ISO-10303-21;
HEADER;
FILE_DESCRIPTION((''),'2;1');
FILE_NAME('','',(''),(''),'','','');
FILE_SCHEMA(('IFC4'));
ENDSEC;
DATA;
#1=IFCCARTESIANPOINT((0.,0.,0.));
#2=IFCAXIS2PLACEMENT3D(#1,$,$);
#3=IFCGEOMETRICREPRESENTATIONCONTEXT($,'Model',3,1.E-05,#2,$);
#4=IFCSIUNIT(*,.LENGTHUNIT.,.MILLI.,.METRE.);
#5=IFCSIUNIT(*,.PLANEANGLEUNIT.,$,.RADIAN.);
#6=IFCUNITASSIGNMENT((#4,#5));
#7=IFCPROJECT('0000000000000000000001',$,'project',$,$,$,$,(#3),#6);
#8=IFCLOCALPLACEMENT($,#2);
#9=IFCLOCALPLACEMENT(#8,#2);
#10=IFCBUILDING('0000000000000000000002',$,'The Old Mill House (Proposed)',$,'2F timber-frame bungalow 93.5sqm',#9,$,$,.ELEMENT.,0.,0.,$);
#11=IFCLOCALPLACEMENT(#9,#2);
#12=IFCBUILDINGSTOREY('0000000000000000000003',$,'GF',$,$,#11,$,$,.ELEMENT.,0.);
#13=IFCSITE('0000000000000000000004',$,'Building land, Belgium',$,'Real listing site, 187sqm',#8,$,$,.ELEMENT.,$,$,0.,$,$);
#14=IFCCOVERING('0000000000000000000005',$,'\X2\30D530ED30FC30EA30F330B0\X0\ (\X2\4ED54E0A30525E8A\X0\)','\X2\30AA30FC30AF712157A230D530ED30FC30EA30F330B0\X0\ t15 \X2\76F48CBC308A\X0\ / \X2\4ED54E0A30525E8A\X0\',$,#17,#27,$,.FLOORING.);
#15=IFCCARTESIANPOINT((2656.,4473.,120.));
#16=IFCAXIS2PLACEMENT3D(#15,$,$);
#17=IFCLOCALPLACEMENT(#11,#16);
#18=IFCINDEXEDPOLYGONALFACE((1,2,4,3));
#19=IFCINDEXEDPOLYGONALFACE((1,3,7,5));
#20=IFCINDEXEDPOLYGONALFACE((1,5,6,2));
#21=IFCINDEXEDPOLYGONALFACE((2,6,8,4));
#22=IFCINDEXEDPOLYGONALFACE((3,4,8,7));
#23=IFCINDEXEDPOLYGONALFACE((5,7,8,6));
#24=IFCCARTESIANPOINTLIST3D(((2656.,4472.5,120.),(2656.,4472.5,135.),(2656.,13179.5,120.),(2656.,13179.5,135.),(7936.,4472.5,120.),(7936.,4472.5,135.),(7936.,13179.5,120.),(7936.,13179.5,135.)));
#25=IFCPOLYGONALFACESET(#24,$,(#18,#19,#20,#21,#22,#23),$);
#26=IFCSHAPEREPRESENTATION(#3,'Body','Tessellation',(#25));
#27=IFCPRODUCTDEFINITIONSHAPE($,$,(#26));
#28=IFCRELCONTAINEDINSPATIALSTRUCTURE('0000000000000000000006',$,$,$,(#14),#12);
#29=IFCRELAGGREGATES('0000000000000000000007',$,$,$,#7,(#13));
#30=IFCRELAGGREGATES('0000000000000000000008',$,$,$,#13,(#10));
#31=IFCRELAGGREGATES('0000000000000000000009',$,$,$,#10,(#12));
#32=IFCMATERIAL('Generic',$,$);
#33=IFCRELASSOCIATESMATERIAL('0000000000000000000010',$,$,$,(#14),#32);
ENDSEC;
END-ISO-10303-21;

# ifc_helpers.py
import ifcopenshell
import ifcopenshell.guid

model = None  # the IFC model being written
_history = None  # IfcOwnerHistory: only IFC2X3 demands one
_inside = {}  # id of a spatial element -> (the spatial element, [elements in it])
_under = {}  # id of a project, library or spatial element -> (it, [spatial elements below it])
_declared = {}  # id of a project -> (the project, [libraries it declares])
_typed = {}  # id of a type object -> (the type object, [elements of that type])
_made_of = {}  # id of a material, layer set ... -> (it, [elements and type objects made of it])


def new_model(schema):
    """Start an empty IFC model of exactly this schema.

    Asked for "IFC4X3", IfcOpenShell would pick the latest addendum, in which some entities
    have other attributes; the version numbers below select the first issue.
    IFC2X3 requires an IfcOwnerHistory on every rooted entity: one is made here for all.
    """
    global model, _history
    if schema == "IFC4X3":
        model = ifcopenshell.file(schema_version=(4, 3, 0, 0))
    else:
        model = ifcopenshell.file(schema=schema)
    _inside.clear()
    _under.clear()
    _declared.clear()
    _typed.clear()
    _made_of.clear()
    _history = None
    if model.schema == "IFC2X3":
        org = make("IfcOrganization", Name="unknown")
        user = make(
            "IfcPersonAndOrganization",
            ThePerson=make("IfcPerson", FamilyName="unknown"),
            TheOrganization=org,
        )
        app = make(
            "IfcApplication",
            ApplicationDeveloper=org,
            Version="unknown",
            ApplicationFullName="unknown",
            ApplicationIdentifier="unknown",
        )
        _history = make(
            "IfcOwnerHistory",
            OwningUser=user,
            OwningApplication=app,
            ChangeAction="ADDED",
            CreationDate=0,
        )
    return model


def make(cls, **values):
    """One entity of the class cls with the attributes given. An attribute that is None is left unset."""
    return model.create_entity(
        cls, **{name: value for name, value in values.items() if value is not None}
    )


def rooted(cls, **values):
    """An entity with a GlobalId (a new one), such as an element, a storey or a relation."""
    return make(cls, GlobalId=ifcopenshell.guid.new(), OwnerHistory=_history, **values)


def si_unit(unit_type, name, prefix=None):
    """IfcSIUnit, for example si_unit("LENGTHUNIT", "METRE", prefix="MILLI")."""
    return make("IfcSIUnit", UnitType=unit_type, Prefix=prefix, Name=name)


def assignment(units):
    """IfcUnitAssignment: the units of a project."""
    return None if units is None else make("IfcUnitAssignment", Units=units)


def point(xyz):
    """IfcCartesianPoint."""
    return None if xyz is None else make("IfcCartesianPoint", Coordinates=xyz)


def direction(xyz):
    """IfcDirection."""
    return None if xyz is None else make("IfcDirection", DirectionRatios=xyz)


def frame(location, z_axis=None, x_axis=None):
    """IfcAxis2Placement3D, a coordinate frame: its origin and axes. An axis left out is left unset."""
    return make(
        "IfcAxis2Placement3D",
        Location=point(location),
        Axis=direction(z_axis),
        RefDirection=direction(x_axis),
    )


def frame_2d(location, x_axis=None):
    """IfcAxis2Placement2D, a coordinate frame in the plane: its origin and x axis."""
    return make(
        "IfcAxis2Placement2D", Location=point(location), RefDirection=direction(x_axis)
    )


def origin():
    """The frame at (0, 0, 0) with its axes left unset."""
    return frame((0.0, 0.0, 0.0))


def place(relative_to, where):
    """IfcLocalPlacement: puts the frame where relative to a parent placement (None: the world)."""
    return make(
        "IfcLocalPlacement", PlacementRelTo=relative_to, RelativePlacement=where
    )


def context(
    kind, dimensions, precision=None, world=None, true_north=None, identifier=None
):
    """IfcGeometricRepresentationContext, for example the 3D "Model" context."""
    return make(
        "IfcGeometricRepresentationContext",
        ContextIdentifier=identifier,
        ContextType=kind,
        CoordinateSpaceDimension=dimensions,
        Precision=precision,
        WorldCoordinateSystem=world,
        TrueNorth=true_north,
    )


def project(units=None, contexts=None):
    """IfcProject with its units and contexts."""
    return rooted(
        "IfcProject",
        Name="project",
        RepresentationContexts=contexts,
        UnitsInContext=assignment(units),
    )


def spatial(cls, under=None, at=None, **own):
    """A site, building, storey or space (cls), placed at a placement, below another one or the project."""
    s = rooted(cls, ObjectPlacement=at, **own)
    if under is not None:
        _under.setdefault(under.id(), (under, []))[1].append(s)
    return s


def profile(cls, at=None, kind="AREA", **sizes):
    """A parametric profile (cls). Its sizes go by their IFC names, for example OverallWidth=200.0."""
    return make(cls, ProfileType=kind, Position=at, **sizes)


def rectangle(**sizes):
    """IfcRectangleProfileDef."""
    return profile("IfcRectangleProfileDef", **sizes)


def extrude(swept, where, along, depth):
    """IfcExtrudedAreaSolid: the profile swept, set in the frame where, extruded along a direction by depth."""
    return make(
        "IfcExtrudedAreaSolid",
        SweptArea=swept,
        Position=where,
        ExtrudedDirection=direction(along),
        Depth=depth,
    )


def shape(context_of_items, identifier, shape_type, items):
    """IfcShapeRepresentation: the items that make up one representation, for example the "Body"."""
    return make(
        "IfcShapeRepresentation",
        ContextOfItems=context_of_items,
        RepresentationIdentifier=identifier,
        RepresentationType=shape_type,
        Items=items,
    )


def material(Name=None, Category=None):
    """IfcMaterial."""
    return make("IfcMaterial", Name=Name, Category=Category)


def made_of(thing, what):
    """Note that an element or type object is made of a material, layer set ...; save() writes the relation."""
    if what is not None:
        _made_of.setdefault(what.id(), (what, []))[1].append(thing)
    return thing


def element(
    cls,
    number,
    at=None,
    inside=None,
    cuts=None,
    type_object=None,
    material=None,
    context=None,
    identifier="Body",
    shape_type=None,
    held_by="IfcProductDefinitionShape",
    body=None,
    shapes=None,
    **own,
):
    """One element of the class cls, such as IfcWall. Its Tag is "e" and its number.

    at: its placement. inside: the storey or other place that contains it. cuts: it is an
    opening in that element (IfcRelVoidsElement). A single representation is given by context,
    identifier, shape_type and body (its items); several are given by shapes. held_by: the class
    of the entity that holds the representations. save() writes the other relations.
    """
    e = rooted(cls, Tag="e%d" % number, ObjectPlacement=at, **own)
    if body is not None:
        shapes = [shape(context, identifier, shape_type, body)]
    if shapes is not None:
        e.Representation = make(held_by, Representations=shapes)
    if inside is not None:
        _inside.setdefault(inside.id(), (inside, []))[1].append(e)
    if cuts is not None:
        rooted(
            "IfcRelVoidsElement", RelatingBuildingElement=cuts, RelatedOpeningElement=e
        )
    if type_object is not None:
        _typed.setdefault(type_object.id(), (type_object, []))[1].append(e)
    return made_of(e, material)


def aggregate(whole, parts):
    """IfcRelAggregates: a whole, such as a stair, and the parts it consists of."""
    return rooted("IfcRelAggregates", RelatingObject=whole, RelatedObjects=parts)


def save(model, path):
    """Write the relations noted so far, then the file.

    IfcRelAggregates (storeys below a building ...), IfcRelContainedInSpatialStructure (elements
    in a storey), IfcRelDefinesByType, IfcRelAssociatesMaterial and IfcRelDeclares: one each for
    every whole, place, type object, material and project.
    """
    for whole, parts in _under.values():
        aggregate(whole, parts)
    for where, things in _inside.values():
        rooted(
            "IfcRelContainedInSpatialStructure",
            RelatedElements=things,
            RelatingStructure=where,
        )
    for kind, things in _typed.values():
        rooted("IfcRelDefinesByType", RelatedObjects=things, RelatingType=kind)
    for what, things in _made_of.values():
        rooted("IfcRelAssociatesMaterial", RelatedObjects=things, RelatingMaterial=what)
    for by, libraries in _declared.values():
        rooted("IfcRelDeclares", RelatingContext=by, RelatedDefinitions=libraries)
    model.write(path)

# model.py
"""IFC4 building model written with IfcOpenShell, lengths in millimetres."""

from ifc_helpers import new_model, si_unit, frame, frame_2d, origin, place, context, project, spatial, rectangle, extrude, material, element, save


model = new_model("IFC4")

# Units and contexts
model_context = context("Model", 3, precision=1e-05, world=origin())
ifc_project = project(units=[si_unit("LENGTHUNIT", "METRE", prefix="MILLI"), si_unit("PLANEANGLEUNIT", "RADIAN")], contexts=[model_context])

# Site, building, storey
site_placement = place(None, origin())
site = spatial("IfcSite", under=ifc_project, at=site_placement, Name="Building land, Belgium", ObjectType="Real listing site, 187sqm", CompositionType="ELEMENT", RefElevation=0.0)
building_placement = place(site_placement, origin())
building = spatial("IfcBuilding", under=site, at=building_placement, Name="The Old Mill House (Proposed)", ObjectType="2F timber-frame bungalow 93.5sqm", CompositionType="ELEMENT", ElevationOfRefHeight=0.0, ElevationOfTerrain=0.0)
storey_placement = place(building_placement, origin())
storey = spatial("IfcBuildingStorey", under=building, at=storey_placement, Name="GF", CompositionType="ELEMENT", Elevation=0.0)

# Covering
ifc_material_1 = material(Name="Generic")
covering_placement = place(storey_placement, frame((2656.0, 4473.0, 120.0)))
element("IfcCovering", 1, at=covering_placement, inside=storey, material=ifc_material_1, Name="フローリング (仕上げ床)", Description="オーク無垢フローリング t15 直貼り / 仕上げ床", PredefinedType="FLOORING", context=model_context, shape_type="SweptSolid", body=[
    extrude(rectangle(XDim=5280.0, YDim=8707.0, at=frame_2d((2640.0, 4353.0))), frame((2656.0, 4473.0, 120.0)), (0.0, 0.0, 1.0), 15.0),
])

save(model, "model.ifc")
